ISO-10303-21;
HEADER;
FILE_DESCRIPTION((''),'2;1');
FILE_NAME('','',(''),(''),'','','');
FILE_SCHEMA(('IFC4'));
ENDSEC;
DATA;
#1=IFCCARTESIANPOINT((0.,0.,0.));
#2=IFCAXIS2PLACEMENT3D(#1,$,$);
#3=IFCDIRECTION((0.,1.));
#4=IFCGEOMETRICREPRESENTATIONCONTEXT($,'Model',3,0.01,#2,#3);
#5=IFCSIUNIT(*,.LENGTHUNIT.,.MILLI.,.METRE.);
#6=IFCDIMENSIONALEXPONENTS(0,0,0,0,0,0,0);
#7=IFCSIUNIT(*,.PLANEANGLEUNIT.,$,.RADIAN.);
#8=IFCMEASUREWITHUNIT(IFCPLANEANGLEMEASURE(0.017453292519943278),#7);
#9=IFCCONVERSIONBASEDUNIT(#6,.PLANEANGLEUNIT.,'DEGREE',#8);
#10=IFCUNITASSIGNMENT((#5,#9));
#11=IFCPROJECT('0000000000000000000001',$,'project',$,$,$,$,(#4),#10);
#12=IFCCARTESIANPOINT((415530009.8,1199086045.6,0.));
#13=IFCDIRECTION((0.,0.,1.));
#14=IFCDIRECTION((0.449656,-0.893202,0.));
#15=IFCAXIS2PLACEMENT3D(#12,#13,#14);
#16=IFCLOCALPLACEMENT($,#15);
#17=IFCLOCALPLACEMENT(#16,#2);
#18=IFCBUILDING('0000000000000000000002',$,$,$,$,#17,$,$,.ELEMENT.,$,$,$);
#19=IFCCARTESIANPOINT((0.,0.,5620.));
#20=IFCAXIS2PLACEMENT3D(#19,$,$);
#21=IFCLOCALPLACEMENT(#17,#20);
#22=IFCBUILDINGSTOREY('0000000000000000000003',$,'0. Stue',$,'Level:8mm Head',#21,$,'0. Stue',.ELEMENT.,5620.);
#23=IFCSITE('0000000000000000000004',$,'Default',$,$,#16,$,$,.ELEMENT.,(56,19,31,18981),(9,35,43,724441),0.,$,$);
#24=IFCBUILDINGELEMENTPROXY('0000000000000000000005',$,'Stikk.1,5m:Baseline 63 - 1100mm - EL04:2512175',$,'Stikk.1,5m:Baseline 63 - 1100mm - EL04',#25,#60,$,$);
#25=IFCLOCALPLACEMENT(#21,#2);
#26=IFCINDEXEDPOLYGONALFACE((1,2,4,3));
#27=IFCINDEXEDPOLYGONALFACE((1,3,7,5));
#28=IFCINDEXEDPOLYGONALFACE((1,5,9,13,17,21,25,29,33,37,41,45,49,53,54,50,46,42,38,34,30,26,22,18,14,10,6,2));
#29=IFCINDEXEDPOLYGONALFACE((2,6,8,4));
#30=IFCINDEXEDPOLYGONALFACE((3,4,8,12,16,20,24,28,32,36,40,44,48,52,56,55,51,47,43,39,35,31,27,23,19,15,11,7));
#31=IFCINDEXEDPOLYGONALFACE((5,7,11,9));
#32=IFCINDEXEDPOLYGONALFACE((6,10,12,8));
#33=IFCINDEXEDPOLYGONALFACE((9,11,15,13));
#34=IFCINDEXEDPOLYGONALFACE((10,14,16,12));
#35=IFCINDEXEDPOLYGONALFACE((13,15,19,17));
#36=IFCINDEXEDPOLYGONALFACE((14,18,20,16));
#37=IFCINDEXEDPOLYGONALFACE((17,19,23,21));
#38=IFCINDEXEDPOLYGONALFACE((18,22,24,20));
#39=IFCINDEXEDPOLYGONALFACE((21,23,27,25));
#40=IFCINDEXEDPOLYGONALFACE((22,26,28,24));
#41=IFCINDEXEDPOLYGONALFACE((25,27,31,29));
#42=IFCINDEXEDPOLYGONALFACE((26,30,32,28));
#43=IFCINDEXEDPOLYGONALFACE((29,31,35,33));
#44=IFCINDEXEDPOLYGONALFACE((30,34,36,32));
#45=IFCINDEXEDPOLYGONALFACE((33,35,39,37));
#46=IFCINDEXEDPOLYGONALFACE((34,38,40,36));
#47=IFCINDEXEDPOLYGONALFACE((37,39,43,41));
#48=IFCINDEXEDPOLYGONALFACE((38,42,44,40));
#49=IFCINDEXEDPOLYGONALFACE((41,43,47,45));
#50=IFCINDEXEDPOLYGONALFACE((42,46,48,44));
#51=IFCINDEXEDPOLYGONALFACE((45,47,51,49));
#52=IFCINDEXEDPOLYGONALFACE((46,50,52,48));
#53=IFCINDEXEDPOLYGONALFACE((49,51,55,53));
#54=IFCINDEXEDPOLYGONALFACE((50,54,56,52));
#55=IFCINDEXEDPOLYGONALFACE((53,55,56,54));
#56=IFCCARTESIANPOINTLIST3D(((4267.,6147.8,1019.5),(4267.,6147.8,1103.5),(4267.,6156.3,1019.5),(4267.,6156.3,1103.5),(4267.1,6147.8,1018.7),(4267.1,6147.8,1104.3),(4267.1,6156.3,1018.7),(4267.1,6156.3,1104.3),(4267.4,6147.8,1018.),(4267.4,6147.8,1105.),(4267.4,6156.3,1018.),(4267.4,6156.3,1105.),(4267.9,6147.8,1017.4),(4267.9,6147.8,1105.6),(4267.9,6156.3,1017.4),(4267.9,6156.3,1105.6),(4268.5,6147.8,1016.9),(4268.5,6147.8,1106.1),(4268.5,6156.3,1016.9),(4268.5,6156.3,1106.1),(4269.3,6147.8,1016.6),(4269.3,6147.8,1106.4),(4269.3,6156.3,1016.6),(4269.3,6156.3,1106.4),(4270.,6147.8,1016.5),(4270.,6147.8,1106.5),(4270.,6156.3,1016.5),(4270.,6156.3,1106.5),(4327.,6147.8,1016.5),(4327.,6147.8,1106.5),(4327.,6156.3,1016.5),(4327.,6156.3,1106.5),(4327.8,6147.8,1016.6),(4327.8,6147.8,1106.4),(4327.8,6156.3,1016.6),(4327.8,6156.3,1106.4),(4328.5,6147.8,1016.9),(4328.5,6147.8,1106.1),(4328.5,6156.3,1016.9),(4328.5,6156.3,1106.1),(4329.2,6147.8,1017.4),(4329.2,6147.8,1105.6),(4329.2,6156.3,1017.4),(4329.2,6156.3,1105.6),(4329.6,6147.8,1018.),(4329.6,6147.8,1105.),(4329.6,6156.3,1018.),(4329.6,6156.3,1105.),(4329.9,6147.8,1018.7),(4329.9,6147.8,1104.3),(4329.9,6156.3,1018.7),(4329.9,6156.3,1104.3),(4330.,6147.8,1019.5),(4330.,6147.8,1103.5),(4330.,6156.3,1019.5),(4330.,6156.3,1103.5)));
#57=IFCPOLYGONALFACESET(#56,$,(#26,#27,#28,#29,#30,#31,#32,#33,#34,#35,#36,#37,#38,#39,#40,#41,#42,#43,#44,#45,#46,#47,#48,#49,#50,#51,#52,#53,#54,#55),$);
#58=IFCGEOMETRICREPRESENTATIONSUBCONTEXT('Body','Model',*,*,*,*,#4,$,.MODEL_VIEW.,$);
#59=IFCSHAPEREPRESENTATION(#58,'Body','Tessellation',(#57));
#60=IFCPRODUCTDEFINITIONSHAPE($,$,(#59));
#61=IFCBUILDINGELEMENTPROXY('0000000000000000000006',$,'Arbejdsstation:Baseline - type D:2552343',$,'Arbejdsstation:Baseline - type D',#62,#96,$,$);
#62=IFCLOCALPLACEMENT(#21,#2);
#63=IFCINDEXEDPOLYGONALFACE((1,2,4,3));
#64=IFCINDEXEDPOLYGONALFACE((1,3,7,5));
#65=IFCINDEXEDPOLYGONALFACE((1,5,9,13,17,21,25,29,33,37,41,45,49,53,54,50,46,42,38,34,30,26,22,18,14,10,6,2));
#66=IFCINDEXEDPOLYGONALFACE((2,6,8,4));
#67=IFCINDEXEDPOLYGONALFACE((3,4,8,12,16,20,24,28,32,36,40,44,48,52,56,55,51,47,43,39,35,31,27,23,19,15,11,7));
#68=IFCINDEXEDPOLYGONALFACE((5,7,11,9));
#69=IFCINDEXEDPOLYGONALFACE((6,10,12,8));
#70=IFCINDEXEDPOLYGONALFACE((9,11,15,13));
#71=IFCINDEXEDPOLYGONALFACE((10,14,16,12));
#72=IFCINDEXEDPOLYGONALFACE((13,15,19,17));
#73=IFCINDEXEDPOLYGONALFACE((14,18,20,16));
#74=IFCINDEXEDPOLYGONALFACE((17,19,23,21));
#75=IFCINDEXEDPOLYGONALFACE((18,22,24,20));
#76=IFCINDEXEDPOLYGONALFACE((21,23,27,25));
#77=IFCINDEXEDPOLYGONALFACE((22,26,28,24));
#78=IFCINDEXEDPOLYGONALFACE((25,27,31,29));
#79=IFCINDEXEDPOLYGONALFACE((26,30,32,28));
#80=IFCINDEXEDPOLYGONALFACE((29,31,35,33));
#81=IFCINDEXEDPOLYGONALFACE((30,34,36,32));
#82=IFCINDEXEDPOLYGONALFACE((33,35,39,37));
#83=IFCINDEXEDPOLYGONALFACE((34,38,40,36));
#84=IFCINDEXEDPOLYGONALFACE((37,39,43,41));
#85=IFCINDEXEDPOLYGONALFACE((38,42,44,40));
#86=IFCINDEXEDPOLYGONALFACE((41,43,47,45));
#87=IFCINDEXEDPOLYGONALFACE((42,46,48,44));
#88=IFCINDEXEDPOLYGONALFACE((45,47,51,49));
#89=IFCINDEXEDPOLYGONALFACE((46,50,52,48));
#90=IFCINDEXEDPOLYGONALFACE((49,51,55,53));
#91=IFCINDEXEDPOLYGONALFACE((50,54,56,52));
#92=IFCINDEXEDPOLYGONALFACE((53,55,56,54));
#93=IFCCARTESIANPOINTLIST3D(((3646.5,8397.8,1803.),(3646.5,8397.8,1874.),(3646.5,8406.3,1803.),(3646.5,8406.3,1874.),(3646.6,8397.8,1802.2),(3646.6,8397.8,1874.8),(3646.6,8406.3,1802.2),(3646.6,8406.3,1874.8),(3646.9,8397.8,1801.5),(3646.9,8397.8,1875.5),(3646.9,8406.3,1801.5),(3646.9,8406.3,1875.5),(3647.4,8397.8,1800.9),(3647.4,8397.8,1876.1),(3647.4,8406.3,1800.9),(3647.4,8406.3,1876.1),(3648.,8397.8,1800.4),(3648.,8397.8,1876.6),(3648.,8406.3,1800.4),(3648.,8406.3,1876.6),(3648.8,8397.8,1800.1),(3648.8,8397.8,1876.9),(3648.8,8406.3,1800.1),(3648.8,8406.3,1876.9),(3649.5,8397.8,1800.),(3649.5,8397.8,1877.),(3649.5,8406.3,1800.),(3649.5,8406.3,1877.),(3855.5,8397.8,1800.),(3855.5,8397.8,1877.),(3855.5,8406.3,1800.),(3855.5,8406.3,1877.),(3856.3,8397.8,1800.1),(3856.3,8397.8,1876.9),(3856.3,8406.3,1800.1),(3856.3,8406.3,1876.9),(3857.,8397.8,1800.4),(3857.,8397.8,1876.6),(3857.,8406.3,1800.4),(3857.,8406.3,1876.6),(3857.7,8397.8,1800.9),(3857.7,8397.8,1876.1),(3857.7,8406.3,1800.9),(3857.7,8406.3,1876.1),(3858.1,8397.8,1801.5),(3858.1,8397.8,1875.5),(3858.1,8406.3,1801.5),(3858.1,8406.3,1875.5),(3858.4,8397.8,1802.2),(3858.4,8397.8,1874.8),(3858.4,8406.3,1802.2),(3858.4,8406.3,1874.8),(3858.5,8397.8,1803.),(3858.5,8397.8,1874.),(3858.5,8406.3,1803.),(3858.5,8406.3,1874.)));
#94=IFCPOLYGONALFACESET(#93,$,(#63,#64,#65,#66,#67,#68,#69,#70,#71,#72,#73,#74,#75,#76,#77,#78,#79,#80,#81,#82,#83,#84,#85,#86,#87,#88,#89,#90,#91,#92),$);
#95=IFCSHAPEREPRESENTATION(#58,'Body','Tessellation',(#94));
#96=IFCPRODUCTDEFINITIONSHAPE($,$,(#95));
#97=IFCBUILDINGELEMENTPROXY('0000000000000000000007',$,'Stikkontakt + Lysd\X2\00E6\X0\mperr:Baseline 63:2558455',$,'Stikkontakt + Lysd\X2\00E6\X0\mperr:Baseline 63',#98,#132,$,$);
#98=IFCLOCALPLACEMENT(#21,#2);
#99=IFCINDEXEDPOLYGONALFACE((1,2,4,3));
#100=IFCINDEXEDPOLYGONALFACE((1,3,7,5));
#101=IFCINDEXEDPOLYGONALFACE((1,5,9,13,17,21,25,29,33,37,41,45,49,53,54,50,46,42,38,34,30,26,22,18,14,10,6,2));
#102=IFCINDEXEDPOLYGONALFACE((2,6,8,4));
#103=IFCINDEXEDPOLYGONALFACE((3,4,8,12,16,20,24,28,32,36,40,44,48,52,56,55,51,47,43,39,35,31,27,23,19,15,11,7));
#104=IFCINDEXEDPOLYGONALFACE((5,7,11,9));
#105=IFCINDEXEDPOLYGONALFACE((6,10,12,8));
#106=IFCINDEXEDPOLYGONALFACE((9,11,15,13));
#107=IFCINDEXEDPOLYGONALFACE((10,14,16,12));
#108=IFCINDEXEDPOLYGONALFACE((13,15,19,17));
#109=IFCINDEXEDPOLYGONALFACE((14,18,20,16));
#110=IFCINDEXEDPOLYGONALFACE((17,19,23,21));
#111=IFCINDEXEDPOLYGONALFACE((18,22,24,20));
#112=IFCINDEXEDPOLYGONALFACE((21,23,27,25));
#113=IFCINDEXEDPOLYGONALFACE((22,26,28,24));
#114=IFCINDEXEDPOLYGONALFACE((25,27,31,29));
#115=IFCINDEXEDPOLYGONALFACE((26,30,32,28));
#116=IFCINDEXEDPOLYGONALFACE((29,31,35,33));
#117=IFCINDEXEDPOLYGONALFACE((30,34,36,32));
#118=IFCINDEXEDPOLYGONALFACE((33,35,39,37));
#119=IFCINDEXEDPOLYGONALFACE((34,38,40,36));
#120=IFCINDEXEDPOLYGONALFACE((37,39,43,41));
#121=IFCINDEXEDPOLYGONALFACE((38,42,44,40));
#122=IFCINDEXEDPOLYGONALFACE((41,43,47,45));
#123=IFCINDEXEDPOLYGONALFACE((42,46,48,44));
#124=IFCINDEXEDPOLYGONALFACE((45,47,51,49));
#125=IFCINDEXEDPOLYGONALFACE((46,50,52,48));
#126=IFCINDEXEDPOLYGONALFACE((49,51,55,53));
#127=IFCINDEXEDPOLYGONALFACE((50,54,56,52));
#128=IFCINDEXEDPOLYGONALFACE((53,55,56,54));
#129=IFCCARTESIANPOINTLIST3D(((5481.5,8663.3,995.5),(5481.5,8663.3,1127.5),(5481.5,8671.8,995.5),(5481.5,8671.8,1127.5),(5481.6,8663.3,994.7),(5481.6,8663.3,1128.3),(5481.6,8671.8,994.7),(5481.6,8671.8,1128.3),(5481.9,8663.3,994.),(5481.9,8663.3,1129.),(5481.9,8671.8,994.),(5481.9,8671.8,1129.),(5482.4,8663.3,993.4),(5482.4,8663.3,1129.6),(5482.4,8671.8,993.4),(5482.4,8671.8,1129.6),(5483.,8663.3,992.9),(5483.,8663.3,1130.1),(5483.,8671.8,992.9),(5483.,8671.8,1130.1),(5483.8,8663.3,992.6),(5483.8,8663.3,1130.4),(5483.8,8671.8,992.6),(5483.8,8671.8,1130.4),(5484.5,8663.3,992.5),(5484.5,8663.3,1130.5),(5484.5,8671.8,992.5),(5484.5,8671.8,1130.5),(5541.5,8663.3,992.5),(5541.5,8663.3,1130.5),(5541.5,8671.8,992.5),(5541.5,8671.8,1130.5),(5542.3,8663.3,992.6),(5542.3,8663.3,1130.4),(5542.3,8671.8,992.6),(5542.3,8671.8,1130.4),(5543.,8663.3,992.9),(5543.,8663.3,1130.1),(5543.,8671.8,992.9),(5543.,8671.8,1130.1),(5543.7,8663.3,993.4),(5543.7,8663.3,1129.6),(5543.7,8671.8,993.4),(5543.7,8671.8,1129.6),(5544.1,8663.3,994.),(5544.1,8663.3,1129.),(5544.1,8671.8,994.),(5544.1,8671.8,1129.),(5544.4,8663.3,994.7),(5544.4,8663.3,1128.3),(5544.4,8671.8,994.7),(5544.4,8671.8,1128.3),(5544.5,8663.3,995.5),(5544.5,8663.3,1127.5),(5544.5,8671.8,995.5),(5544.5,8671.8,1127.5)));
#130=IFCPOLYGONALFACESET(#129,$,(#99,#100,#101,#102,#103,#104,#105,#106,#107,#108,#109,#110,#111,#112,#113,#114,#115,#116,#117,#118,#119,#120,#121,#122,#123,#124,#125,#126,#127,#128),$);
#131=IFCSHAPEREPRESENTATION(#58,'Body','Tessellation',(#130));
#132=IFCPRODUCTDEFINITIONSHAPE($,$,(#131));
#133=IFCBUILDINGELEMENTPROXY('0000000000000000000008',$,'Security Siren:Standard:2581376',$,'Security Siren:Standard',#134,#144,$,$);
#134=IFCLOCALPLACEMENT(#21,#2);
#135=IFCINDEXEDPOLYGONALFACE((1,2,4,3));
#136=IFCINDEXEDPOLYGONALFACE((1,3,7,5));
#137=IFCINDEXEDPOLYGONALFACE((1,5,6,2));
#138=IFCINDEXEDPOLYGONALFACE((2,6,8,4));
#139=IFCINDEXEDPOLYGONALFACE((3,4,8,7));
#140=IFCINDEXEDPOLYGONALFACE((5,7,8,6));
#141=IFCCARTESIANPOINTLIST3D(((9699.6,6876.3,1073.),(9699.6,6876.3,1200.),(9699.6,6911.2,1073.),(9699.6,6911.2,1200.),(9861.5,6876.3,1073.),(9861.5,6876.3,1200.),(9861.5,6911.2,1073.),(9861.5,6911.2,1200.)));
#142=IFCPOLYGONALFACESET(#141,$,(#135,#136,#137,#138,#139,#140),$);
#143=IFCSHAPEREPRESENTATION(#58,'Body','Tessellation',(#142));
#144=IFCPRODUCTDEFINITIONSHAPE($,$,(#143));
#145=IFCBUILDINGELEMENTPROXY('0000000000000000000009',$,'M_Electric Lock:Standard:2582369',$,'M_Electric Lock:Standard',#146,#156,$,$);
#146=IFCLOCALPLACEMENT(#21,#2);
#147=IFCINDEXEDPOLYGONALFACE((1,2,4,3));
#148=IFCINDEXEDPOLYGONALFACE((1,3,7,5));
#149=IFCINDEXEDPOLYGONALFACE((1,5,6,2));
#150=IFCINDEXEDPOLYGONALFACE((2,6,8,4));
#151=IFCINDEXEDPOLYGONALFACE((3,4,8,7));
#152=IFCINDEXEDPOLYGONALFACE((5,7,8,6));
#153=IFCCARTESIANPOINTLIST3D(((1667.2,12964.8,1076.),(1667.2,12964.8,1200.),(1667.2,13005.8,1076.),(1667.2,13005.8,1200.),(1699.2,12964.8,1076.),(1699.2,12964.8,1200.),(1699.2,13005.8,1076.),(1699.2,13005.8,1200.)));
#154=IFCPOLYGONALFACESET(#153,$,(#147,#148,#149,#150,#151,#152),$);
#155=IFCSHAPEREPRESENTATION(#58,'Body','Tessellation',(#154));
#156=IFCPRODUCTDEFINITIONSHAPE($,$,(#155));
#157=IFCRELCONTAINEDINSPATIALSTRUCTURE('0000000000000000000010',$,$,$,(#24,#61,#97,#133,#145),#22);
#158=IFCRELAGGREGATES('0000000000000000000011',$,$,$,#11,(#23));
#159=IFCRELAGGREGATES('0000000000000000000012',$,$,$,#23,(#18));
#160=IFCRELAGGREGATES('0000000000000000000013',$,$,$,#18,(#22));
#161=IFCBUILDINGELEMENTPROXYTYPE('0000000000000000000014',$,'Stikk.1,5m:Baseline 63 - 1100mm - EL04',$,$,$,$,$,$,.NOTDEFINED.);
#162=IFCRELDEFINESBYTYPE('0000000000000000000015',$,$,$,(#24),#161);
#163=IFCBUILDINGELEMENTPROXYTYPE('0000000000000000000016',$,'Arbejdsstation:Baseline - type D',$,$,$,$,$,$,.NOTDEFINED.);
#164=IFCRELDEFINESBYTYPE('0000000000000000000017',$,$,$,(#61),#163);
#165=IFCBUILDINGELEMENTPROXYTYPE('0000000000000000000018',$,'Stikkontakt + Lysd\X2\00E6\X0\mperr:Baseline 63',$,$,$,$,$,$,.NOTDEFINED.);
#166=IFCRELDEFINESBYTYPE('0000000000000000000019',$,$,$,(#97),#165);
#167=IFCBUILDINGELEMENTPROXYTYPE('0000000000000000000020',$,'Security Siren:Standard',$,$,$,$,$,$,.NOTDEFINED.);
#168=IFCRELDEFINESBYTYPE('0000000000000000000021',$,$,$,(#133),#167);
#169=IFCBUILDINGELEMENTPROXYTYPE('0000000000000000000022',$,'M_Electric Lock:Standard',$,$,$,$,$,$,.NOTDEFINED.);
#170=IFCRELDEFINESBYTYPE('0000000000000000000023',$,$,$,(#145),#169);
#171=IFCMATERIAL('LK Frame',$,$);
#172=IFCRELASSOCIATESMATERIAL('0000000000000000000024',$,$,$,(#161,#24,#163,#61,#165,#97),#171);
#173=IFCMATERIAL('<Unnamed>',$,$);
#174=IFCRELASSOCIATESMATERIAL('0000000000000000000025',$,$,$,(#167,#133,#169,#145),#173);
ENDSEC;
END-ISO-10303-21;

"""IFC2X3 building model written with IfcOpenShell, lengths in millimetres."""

from ifc_helpers import new_model, entity, si_unit, converted_unit, direction, frame, frame_2d, origin, origin_2d_with_axis, place, context, subcontext, project, spatial, polyline, circle_curve, parameter, trimmed, segment, composite_curve, rectangle, outline, extrude, source, transform, mapped, material, type_object, type_shapes, element, save


model = new_model("IFC2X3")

# Units and contexts
model_context = context("Model", 3, precision=0.01, world=origin(), true_north=direction((0.0, 1.0)))
body_context = subcontext(model_context, "Body", "Model", "MODEL_VIEW")
ifc_project = project(units=[si_unit("LENGTHUNIT", "METRE", prefix="MILLI"), converted_unit("PLANEANGLEUNIT", "DEGREE", entity("IfcPlaneAngleMeasure", 0.017453292519943278), si_unit("PLANEANGLEUNIT", "RADIAN"), dimensions=[0, 0, 0, 0, 0, 0, 0])], contexts=[model_context])

# Site, building, storey
site_placement = place(None, frame((415530009.8, 1199086045.6, 0.0), z_axis=(0.0, 0.0, 1.0), x_axis=(0.449656, -0.893202, 0.0)))
site = spatial("IfcSite", under=ifc_project, at=site_placement, Name="Default", CompositionType="ELEMENT", RefLatitude=(56, 19, 31, 18981), RefLongitude=(9, 35, 43, 724441), RefElevation=0.0)
building_placement = place(site_placement, origin())
building = spatial("IfcBuilding", under=site, at=building_placement, CompositionType="ELEMENT")
storey_placement = place(building_placement, frame((0.0, 0.0, 5620.0)))
storey = spatial("IfcBuildingStorey", under=building, at=storey_placement, Name="0. Stue", ObjectType="Level:8mm Head", LongName="0. Stue", CompositionType="ELEMENT", Elevation=5620.0)

# Building element proxies
ifc_material_1 = material(Name="LK Frame")
building_element_proxy_type_1 = type_object("IfcBuildingElementProxyType", Name="Stikk.1,5m:Baseline 63 - 1100mm - EL04", PredefinedType="NOTDEFINED", material=ifc_material_1)
shared_shape_1 = source(origin(), body_context, "Body", "SweptSolid", [
    extrude(outline(composite_curve([segment(trimmed(circle_curve(frame_2d((-42.0, 28.5), x_axis=(1.0, 0.0)), 3.0), [parameter(90.0)], [parameter(180.0)], True, "PARAMETER"), True, "CONTINUOUS"), segment(polyline([(-45.0, 28.5), (-45.0, -28.5)]), True, "CONTINUOUS"), segment(trimmed(circle_curve(frame_2d((-42.0, -28.5), x_axis=(1.0, 0.0)), 3.0), [parameter(180.0)], [parameter(270.0)], True, "PARAMETER"), True, "CONTINUOUS"), segment(polyline([(-42.0, -31.5), (42.0, -31.5)]), True, "CONTINUOUS"), segment(trimmed(circle_curve(frame_2d((42.0, -28.5), x_axis=(-1.0, 0.0)), 3.0), [parameter(90.0)], [parameter(180.0)], True, "PARAMETER"), True, "CONTINUOUS"), segment(polyline([(45.0, -28.5), (45.0, 28.5)]), True, "CONTINUOUS"), segment(trimmed(circle_curve(frame_2d((42.0, 28.5), x_axis=(-1.0, 0.0)), 3.0), [parameter(180.0)], [parameter(270.0)], True, "PARAMETER"), True, "CONTINUOUS"), segment(polyline([(42.0, 31.5), (-42.0, 31.5)]), True, "CONTINUOUS")], self_intersect=False)), frame((0.0, 38.5, 0.0), z_axis=(0.0, 0.0, 1.0), x_axis=(0.0, -1.0, 0.0)), (0.0, 0.0, 1.0), 8.5),
])
type_shapes(building_element_proxy_type_1, [shared_shape_1])
proxy_1_placement = place(storey_placement, frame((4298.5, 6156.3, 1100.0), z_axis=(0.0, -1.0, 0.0), x_axis=(-1.0, 0.0, 0.0)))
element("IfcBuildingElementProxy", 1, at=proxy_1_placement, inside=storey, type_object=building_element_proxy_type_1, material=ifc_material_1, Name="Stikk.1,5m:Baseline 63 - 1100mm - EL04:2512175", ObjectType="Stikk.1,5m:Baseline 63 - 1100mm - EL04", context=body_context, shape_type="MappedRepresentation", body=[
    mapped(shared_shape_1, transform((0.0, 0.0, 0.0), scale=1.0)),
])
building_element_proxy_type_2 = type_object("IfcBuildingElementProxyType", Name="Arbejdsstation:Baseline - type D", PredefinedType="NOTDEFINED", material=ifc_material_1)
shared_shape_2 = source(origin(), body_context, "Body", "SweptSolid", [
    extrude(outline(composite_curve([segment(polyline([(-35.5, -106.0), (35.5, -106.0)]), True, "CONTINUOUS"), segment(trimmed(circle_curve(frame_2d((35.5, -103.0), x_axis=(-1.0, 0.0)), 3.0), [parameter(90.0)], [parameter(180.0)], True, "PARAMETER"), True, "CONTINUOUS"), segment(polyline([(38.5, -103.0), (38.5, 103.0)]), True, "CONTINUOUS"), segment(trimmed(circle_curve(frame_2d((35.5, 103.0), x_axis=(-1.0, 0.0)), 3.0), [parameter(180.0)], [parameter(270.0)], True, "PARAMETER"), True, "CONTINUOUS"), segment(polyline([(35.5, 106.0), (-35.5, 106.0)]), True, "CONTINUOUS"), segment(trimmed(circle_curve(frame_2d((-35.5, 103.0), x_axis=(1.0, 0.0)), 3.0), [parameter(90.0)], [parameter(180.0)], True, "PARAMETER"), True, "CONTINUOUS"), segment(polyline([(-38.5, 103.0), (-38.5, -103.0)]), True, "CONTINUOUS"), segment(trimmed(circle_curve(frame_2d((-35.5, -103.0), x_axis=(1.0, 0.0)), 3.0), [parameter(180.0)], [parameter(270.0)], True, "PARAMETER"), True, "CONTINUOUS")], self_intersect=False)), frame((-3.5, -38.5, 0.0), z_axis=(0.0, 0.0, 1.0), x_axis=(0.0, 1.0, 0.0)), (0.0, 0.0, 1.0), 8.5),
])
type_shapes(building_element_proxy_type_2, [shared_shape_2])
proxy_2_placement = place(storey_placement, frame((3749.0, 8406.3, 1800.0), z_axis=(0.0, -1.0, 0.0), x_axis=(-1.0, 0.0, 0.0)))
element("IfcBuildingElementProxy", 2, at=proxy_2_placement, inside=storey, type_object=building_element_proxy_type_2, material=ifc_material_1, Name="Arbejdsstation:Baseline - type D:2552343", ObjectType="Arbejdsstation:Baseline - type D", context=body_context, shape_type="MappedRepresentation", body=[
    mapped(shared_shape_2, transform((0.0, 0.0, 0.0), scale=1.0)),
])
building_element_proxy_type_3 = type_object("IfcBuildingElementProxyType", Name="Stikkontakt + Lysdæmperr:Baseline 63", PredefinedType="NOTDEFINED", material=ifc_material_1)
shared_shape_3 = source(origin(), body_context, "Body", "SweptSolid", [
    extrude(outline(composite_curve([segment(polyline([(-66.0, -31.5), (66.0, -31.5)]), True, "CONTINUOUS"), segment(trimmed(circle_curve(frame_2d((66.0, -28.5), x_axis=(-1.0, 0.0)), 3.0), [parameter(90.0)], [parameter(180.0)], True, "PARAMETER"), True, "CONTINUOUS"), segment(polyline([(69.0, -28.5), (69.0, 28.5)]), True, "CONTINUOUS"), segment(trimmed(circle_curve(frame_2d((66.0, 28.5), x_axis=(-1.0, 0.0)), 3.0), [parameter(180.0)], [parameter(270.0)], True, "PARAMETER"), True, "CONTINUOUS"), segment(polyline([(66.0, 31.5), (-66.0, 31.5)]), True, "CONTINUOUS"), segment(trimmed(circle_curve(frame_2d((-66.0, 28.5), x_axis=(1.0, 0.0)), 3.0), [parameter(90.0)], [parameter(180.0)], True, "PARAMETER"), True, "CONTINUOUS"), segment(polyline([(-69.0, 28.5), (-69.0, -28.5)]), True, "CONTINUOUS"), segment(trimmed(circle_curve(frame_2d((-66.0, -28.5), x_axis=(1.0, 0.0)), 3.0), [parameter(180.0)], [parameter(270.0)], True, "PARAMETER"), True, "CONTINUOUS")], self_intersect=False)), frame((0.0, -38.5, 0.0), z_axis=(0.0, 0.0, 1.0), x_axis=(0.0, 1.0, 0.0)), (0.0, 0.0, 1.0), 8.5),
])
type_shapes(building_element_proxy_type_3, [shared_shape_3])
proxy_3_placement = place(storey_placement, frame((5513.0, 8663.3, 1100.0), z_axis=(0.0, 1.0, 0.0), x_axis=(-1.0, 0.0, 0.0)))
element("IfcBuildingElementProxy", 3, at=proxy_3_placement, inside=storey, type_object=building_element_proxy_type_3, material=ifc_material_1, Name="Stikkontakt + Lysdæmperr:Baseline 63:2558455", ObjectType="Stikkontakt + Lysdæmperr:Baseline 63", context=body_context, shape_type="MappedRepresentation", body=[
    mapped(shared_shape_3, transform((0.0, 0.0, 0.0), scale=1.0)),
])
ifc_material_2 = material(Name="<Unnamed>")
building_element_proxy_type_4 = type_object("IfcBuildingElementProxyType", Name="Security Siren:Standard", PredefinedType="NOTDEFINED", material=ifc_material_2)
shared_shape_4 = source(origin(), body_context, "Body", "SweptSolid", [
    extrude(rectangle(XDim=161.9, YDim=127.0, at=origin_2d_with_axis()), frame((0.0, -63.5, 0.0), z_axis=(0.0, 0.0, 1.0), x_axis=(-1.0, 0.0, 0.0)), (0.0, 0.0, 1.0), 34.9),
])
type_shapes(building_element_proxy_type_4, [shared_shape_4])
proxy_4_placement = place(storey_placement, frame((9780.5, 6876.3, 1200.0), z_axis=(0.0, 1.0, 0.0), x_axis=(-1.0, 0.0, 0.0)))
element("IfcBuildingElementProxy", 4, at=proxy_4_placement, inside=storey, type_object=building_element_proxy_type_4, material=ifc_material_2, Name="Security Siren:Standard:2581376", ObjectType="Security Siren:Standard", context=body_context, shape_type="MappedRepresentation", body=[
    mapped(shared_shape_4, transform((0.0, 0.0, 0.0), scale=1.0)),
])
building_element_proxy_type_5 = type_object("IfcBuildingElementProxyType", Name="M_Electric Lock:Standard", PredefinedType="NOTDEFINED", material=ifc_material_2)
shared_shape_5 = source(origin(), body_context, "Body", "SweptSolid", [
    extrude(rectangle(XDim=32.0, YDim=124.0, at=origin_2d_with_axis()), frame((0.0, -62.0, 0.0), z_axis=(0.0, 0.0, 1.0), x_axis=(-1.0, 0.0, 0.0)), (0.0, 0.0, 1.0), 41.0),
])
type_shapes(building_element_proxy_type_5, [shared_shape_5])
proxy_5_placement = place(storey_placement, frame((1683.2, 12964.8, 1200.0), z_axis=(0.0, 1.0, 0.0), x_axis=(-1.0, 0.0, 0.0)))
element("IfcBuildingElementProxy", 5, at=proxy_5_placement, inside=storey, type_object=building_element_proxy_type_5, material=ifc_material_2, Name="M_Electric Lock:Standard:2582369", ObjectType="M_Electric Lock:Standard", context=body_context, shape_type="MappedRepresentation", body=[
    mapped(shared_shape_5, transform((0.0, 0.0, 0.0), scale=1.0)),
])

save(model, "model.ifc")
